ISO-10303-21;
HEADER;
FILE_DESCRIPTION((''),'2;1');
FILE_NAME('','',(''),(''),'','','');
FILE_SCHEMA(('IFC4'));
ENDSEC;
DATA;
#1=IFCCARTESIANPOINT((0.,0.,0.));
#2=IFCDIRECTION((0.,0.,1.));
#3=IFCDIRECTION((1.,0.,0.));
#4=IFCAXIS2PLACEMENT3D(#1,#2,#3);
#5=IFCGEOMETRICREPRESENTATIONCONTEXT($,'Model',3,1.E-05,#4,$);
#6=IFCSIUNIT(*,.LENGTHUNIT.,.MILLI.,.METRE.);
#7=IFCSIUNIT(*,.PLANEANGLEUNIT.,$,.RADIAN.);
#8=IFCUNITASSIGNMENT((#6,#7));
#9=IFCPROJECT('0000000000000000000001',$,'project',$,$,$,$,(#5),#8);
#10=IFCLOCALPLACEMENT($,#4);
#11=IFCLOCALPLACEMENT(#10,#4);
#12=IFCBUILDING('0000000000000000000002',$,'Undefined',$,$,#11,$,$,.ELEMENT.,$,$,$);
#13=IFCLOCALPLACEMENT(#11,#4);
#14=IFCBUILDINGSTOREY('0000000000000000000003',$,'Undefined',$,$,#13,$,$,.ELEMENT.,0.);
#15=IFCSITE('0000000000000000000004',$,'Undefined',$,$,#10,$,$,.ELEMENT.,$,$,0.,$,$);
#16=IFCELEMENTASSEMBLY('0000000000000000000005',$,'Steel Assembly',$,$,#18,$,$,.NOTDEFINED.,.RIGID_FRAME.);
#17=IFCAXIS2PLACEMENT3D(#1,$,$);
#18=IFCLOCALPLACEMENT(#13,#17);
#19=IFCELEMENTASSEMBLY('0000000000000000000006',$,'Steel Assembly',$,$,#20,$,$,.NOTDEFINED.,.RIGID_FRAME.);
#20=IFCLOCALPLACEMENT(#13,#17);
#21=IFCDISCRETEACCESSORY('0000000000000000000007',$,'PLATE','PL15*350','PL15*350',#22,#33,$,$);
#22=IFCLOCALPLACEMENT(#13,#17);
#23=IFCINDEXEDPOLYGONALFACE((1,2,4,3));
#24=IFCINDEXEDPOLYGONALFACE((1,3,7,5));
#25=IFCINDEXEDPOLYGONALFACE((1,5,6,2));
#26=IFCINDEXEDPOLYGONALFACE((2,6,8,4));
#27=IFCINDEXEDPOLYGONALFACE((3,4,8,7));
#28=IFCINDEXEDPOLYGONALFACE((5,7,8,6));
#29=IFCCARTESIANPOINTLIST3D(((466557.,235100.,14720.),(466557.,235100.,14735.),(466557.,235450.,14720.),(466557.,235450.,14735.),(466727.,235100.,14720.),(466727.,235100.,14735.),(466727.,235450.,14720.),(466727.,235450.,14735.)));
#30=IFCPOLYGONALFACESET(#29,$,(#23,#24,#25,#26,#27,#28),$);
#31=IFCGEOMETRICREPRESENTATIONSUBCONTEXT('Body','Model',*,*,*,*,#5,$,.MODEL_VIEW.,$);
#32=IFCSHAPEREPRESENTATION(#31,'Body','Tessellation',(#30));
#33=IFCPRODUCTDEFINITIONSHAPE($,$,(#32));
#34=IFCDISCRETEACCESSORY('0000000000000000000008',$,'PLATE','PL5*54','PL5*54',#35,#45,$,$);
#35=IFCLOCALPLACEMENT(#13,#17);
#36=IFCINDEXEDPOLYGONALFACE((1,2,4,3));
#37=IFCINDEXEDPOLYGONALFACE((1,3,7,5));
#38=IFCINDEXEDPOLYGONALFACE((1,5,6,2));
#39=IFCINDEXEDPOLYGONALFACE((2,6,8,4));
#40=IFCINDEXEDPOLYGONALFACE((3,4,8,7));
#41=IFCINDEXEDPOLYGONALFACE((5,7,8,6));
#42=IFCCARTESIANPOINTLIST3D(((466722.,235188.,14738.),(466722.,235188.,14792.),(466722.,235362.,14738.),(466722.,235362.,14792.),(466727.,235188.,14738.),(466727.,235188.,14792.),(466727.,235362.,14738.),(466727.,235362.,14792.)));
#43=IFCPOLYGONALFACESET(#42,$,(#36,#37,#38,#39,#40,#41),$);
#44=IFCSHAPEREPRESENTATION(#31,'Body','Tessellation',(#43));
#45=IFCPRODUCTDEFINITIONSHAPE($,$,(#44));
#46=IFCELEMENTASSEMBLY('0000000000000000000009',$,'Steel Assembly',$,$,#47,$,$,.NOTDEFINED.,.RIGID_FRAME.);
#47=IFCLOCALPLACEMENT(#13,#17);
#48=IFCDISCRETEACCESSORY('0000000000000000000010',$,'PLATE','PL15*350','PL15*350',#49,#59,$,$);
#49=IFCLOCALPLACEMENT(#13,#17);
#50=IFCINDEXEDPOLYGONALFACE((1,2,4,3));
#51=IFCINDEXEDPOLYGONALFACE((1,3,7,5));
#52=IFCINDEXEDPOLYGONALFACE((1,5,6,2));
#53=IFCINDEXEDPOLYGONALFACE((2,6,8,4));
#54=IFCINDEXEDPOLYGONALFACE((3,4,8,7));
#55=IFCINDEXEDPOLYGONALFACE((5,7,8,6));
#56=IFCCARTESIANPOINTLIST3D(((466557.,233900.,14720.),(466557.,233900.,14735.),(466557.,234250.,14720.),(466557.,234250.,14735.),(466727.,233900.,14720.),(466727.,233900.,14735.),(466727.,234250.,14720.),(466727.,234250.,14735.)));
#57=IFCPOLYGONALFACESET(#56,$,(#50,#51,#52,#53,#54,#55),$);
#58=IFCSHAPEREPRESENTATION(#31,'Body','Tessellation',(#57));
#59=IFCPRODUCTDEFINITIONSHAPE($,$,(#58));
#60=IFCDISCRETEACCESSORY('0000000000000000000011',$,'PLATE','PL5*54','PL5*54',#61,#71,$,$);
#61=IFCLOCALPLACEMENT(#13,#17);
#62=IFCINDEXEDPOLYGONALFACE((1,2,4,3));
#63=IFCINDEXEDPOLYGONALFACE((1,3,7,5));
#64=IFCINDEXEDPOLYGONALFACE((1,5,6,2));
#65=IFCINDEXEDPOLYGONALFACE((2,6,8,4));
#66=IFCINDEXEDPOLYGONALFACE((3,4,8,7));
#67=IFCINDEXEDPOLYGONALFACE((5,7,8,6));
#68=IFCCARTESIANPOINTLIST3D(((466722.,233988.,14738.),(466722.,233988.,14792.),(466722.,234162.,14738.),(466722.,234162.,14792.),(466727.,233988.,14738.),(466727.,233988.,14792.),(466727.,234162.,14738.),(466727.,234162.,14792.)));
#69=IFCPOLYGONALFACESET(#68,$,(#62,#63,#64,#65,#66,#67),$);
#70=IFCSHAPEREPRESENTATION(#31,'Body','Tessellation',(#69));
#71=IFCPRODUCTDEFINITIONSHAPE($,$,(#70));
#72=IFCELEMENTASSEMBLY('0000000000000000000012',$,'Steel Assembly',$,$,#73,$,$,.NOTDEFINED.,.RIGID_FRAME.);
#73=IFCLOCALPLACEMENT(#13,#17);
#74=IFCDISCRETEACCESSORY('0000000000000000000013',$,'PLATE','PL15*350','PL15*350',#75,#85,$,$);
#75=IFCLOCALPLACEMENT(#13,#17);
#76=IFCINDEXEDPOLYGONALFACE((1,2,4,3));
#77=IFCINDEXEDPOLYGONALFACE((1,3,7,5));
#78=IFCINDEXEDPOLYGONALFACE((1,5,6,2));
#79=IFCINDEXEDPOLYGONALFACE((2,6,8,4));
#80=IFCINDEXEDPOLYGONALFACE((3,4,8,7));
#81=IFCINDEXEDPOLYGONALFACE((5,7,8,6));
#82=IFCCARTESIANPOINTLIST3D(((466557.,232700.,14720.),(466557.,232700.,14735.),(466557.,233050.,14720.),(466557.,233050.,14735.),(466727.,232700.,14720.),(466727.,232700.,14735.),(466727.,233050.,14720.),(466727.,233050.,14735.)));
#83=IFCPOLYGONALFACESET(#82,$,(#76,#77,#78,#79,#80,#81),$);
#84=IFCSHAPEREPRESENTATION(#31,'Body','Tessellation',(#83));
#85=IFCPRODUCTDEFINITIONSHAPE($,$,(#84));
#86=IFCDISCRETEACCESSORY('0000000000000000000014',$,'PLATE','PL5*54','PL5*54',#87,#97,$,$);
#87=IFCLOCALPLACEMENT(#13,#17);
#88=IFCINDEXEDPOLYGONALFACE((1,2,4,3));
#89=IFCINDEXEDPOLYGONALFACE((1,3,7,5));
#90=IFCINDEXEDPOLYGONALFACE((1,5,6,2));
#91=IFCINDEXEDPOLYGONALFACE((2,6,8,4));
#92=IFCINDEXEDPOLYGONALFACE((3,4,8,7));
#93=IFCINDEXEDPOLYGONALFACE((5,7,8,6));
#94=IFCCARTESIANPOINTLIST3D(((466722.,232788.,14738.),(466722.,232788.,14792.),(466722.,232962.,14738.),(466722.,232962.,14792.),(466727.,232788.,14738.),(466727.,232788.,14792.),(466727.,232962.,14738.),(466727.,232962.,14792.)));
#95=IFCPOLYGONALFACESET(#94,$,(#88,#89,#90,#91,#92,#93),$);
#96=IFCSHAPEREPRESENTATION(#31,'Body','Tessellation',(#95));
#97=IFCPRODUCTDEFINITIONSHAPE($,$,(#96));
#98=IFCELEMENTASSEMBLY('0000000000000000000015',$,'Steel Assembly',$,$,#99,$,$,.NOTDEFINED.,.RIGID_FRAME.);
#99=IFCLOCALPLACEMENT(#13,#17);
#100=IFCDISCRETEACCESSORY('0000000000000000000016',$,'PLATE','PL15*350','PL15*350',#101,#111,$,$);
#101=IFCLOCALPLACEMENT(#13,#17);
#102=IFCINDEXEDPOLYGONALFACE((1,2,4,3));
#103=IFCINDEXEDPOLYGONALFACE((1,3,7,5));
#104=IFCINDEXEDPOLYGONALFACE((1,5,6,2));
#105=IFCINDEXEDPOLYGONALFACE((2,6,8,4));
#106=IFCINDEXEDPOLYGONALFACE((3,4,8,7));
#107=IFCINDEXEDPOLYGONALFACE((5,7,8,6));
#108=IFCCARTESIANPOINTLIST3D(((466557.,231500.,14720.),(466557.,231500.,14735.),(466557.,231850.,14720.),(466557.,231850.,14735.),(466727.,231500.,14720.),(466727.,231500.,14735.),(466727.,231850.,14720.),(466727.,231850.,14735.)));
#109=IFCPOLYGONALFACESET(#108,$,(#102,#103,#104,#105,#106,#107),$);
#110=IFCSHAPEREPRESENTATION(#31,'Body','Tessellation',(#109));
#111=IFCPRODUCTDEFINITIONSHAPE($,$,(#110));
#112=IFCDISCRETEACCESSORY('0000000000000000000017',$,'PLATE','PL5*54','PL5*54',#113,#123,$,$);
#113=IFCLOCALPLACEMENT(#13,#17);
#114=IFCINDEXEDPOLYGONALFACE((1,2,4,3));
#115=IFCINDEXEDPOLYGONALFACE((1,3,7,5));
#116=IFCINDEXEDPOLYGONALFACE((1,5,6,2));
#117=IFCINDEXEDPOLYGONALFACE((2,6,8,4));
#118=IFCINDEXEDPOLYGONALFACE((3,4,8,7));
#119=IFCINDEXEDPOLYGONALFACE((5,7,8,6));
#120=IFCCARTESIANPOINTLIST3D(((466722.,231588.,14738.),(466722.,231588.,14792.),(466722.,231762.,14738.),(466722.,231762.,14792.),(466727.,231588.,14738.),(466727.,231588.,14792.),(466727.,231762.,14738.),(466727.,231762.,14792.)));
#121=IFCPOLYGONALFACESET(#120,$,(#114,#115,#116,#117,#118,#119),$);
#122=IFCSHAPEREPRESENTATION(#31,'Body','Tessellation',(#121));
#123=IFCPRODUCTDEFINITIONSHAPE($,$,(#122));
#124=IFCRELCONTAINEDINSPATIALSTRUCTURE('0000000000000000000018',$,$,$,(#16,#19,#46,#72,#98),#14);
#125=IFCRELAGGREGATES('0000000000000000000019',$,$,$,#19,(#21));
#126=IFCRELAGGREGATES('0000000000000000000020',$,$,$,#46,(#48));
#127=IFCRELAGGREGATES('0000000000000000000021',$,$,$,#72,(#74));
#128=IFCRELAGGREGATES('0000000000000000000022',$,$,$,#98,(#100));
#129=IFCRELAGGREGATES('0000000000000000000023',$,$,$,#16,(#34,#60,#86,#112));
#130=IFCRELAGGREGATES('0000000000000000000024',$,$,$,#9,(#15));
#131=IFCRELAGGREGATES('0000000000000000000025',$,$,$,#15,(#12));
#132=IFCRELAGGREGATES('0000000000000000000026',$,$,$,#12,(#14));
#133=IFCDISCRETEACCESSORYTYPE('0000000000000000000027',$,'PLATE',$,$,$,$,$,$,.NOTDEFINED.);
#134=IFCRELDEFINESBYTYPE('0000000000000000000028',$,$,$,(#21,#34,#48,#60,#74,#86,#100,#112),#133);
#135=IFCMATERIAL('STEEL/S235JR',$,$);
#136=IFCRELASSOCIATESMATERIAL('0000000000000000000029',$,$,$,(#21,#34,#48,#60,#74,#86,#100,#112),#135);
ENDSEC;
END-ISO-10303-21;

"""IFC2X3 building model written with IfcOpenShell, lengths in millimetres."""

from ifc_helpers import new_model, si_unit, frame, origin_with_axes, place, context, subcontext, project, spatial, polyline, outline, extrude, material, type_object, element, aggregate, save


model = new_model("IFC2X3")

# Units and contexts
model_context = context("Model", 3, precision=1e-05, world=origin_with_axes())
body_context = subcontext(model_context, "Body", "Model", "MODEL_VIEW")
ifc_project = project(units=[si_unit("LENGTHUNIT", "METRE", prefix="MILLI"), si_unit("PLANEANGLEUNIT", "RADIAN")], contexts=[model_context])

# Site, building, storey
site_placement = place(None, origin_with_axes())
site = spatial("IfcSite", under=ifc_project, at=site_placement, Name="Undefined", CompositionType="ELEMENT", RefElevation=0.0)
building_placement = place(site_placement, origin_with_axes())
building = spatial("IfcBuilding", under=site, at=building_placement, Name="Undefined", CompositionType="ELEMENT")
storey_placement = place(building_placement, origin_with_axes())
storey = spatial("IfcBuildingStorey", under=building, at=storey_placement, Name="Undefined", CompositionType="ELEMENT", Elevation=0.0)

# Shared definitions
ifc_material_1 = material(Name="STEEL/S235JR")

# Shared definitions
discrete_accessory_type_1 = type_object("IfcDiscreteAccessoryType", Name="PLATE")

# Element assemblies, discrete accessory
assembly_1_placement = place(storey_placement, origin_with_axes())
assembly_1 = element("IfcElementAssembly", 1, at=assembly_1_placement, inside=storey, Name="Steel Assembly", AssemblyPlace="NOTDEFINED", PredefinedType="RIGID_FRAME")
assembly_2_placement = place(storey_placement, origin_with_axes())
assembly_2 = element("IfcElementAssembly", 2, at=assembly_2_placement, inside=storey, Name="Steel Assembly", AssemblyPlace="NOTDEFINED", PredefinedType="RIGID_FRAME")
discrete_accessory_1_placement = place(assembly_2_placement, frame((466727.0, 235275.0, 14727.5), z_axis=(0.0, 0.0, 1.0), x_axis=(-1.0, 0.0, 0.0)))
discrete_accessory_1 = element("IfcDiscreteAccessory", 3, at=discrete_accessory_1_placement, type_object=discrete_accessory_type_1, material=ifc_material_1, Name="PLATE", Description="PL15*350", ObjectType="PL15*350", context=body_context, shape_type="SweptSolid", body=[
    extrude(outline(polyline([(170.0, -175.0), (0.0, -175.0), (0.0, 175.0), (170.0, 175.0), (170.0, -175.0)])), frame((0.0, 0.0, -7.5), z_axis=(0.0, 0.0, 1.0), x_axis=(1.0, 0.0, 0.0)), (0.0, 0.0, 1.0), 15.0),
])
aggregate(assembly_2, [discrete_accessory_1])

# Discrete accessory
discrete_accessory_2_placement = place(assembly_1_placement, frame((466724.5, 235188.0, 14765.0), z_axis=(-1.0, 0.0, 0.0), x_axis=(0.0, 1.0, 0.0)))
discrete_accessory_2 = element("IfcDiscreteAccessory", 4, at=discrete_accessory_2_placement, type_object=discrete_accessory_type_1, material=ifc_material_1, Name="PLATE", Description="PL5*54", ObjectType="PL5*54", context=body_context, shape_type="SweptSolid", body=[
    extrude(outline(polyline([(174.0, 27.0), (174.0, -27.0), (0.0, -27.0), (0.0, 27.0), (174.0, 27.0)])), frame((0.0, 0.0, -2.5), z_axis=(0.0, 0.0, 1.0), x_axis=(1.0, 0.0, 0.0)), (0.0, 0.0, 1.0), 5.0),
])

# Element assembly, discrete accessory
assembly_3_placement = place(storey_placement, origin_with_axes())
assembly_3 = element("IfcElementAssembly", 5, at=assembly_3_placement, inside=storey, Name="Steel Assembly", AssemblyPlace="NOTDEFINED", PredefinedType="RIGID_FRAME")
discrete_accessory_3_placement = place(assembly_3_placement, frame((466727.0, 234075.0, 14727.5), z_axis=(0.0, 0.0, 1.0), x_axis=(-1.0, 0.0, 0.0)))
discrete_accessory_3 = element("IfcDiscreteAccessory", 6, at=discrete_accessory_3_placement, type_object=discrete_accessory_type_1, material=ifc_material_1, Name="PLATE", Description="PL15*350", ObjectType="PL15*350", context=body_context, shape_type="SweptSolid", body=[
    extrude(outline(polyline([(170.0, -175.0), (0.0, -175.0), (0.0, 175.0), (170.0, 175.0), (170.0, -175.0)])), frame((0.0, 0.0, -7.5), z_axis=(0.0, 0.0, 1.0), x_axis=(1.0, 0.0, 0.0)), (0.0, 0.0, 1.0), 15.0),
])
aggregate(assembly_3, [discrete_accessory_3])

# Discrete accessory
discrete_accessory_4_placement = place(assembly_1_placement, frame((466724.5, 233988.0, 14765.0), z_axis=(-1.0, 0.0, 0.0), x_axis=(0.0, 1.0, 0.0)))
discrete_accessory_4 = element("IfcDiscreteAccessory", 7, at=discrete_accessory_4_placement, type_object=discrete_accessory_type_1, material=ifc_material_1, Name="PLATE", Description="PL5*54", ObjectType="PL5*54", context=body_context, shape_type="SweptSolid", body=[
    extrude(outline(polyline([(174.0, 27.0), (174.0, -27.0), (0.0, -27.0), (0.0, 27.0), (174.0, 27.0)])), frame((0.0, 0.0, -2.5), z_axis=(0.0, 0.0, 1.0), x_axis=(1.0, 0.0, 0.0)), (0.0, 0.0, 1.0), 5.0),
])

# Element assembly, discrete accessory
assembly_4_placement = place(storey_placement, origin_with_axes())
assembly_4 = element("IfcElementAssembly", 8, at=assembly_4_placement, inside=storey, Name="Steel Assembly", AssemblyPlace="NOTDEFINED", PredefinedType="RIGID_FRAME")
discrete_accessory_5_placement = place(assembly_4_placement, frame((466727.0, 232875.0, 14727.5), z_axis=(0.0, 0.0, 1.0), x_axis=(-1.0, 0.0, 0.0)))
discrete_accessory_5 = element("IfcDiscreteAccessory", 9, at=discrete_accessory_5_placement, type_object=discrete_accessory_type_1, material=ifc_material_1, Name="PLATE", Description="PL15*350", ObjectType="PL15*350", context=body_context, shape_type="SweptSolid", body=[
    extrude(outline(polyline([(170.0, -175.0), (0.0, -175.0), (0.0, 175.0), (170.0, 175.0), (170.0, -175.0)])), frame((0.0, 0.0, -7.5), z_axis=(0.0, 0.0, 1.0), x_axis=(1.0, 0.0, 0.0)), (0.0, 0.0, 1.0), 15.0),
])
aggregate(assembly_4, [discrete_accessory_5])

# Discrete accessory
discrete_accessory_6_placement = place(assembly_1_placement, frame((466724.5, 232788.0, 14765.0), z_axis=(-1.0, 0.0, 0.0), x_axis=(0.0, 1.0, 0.0)))
discrete_accessory_6 = element("IfcDiscreteAccessory", 10, at=discrete_accessory_6_placement, type_object=discrete_accessory_type_1, material=ifc_material_1, Name="PLATE", Description="PL5*54", ObjectType="PL5*54", context=body_context, shape_type="SweptSolid", body=[
    extrude(outline(polyline([(174.0, 27.0), (174.0, -27.0), (0.0, -27.0), (0.0, 27.0), (174.0, 27.0)])), frame((0.0, 0.0, -2.5), z_axis=(0.0, 0.0, 1.0), x_axis=(1.0, 0.0, 0.0)), (0.0, 0.0, 1.0), 5.0),
])

# Element assembly, discrete accessory
assembly_5_placement = place(storey_placement, origin_with_axes())
assembly_5 = element("IfcElementAssembly", 11, at=assembly_5_placement, inside=storey, Name="Steel Assembly", AssemblyPlace="NOTDEFINED", PredefinedType="RIGID_FRAME")
discrete_accessory_7_placement = place(assembly_5_placement, frame((466727.0, 231675.0, 14727.5), z_axis=(0.0, 0.0, 1.0), x_axis=(-1.0, 0.0, 0.0)))
discrete_accessory_7 = element("IfcDiscreteAccessory", 12, at=discrete_accessory_7_placement, type_object=discrete_accessory_type_1, material=ifc_material_1, Name="PLATE", Description="PL15*350", ObjectType="PL15*350", context=body_context, shape_type="SweptSolid", body=[
    extrude(outline(polyline([(170.0, -175.0), (0.0, -175.0), (0.0, 175.0), (170.0, 175.0), (170.0, -175.0)])), frame((0.0, 0.0, -7.5), z_axis=(0.0, 0.0, 1.0), x_axis=(1.0, 0.0, 0.0)), (0.0, 0.0, 1.0), 15.0),
])
aggregate(assembly_5, [discrete_accessory_7])

# Discrete accessory
discrete_accessory_8_placement = place(assembly_1_placement, frame((466724.5, 231588.0, 14765.0), z_axis=(-1.0, 0.0, 0.0), x_axis=(0.0, 1.0, 0.0)))
discrete_accessory_8 = element("IfcDiscreteAccessory", 13, at=discrete_accessory_8_placement, type_object=discrete_accessory_type_1, material=ifc_material_1, Name="PLATE", Description="PL5*54", ObjectType="PL5*54", context=body_context, shape_type="SweptSolid", body=[
    extrude(outline(polyline([(174.0, 27.0), (174.0, -27.0), (0.0, -27.0), (0.0, 27.0), (174.0, 27.0)])), frame((0.0, 0.0, -2.5), z_axis=(0.0, 0.0, 1.0), x_axis=(1.0, 0.0, 0.0)), (0.0, 0.0, 1.0), 5.0),
])
aggregate(assembly_1, [discrete_accessory_2, discrete_accessory_4, discrete_accessory_6, discrete_accessory_8])

save(model, "model.ifc")
